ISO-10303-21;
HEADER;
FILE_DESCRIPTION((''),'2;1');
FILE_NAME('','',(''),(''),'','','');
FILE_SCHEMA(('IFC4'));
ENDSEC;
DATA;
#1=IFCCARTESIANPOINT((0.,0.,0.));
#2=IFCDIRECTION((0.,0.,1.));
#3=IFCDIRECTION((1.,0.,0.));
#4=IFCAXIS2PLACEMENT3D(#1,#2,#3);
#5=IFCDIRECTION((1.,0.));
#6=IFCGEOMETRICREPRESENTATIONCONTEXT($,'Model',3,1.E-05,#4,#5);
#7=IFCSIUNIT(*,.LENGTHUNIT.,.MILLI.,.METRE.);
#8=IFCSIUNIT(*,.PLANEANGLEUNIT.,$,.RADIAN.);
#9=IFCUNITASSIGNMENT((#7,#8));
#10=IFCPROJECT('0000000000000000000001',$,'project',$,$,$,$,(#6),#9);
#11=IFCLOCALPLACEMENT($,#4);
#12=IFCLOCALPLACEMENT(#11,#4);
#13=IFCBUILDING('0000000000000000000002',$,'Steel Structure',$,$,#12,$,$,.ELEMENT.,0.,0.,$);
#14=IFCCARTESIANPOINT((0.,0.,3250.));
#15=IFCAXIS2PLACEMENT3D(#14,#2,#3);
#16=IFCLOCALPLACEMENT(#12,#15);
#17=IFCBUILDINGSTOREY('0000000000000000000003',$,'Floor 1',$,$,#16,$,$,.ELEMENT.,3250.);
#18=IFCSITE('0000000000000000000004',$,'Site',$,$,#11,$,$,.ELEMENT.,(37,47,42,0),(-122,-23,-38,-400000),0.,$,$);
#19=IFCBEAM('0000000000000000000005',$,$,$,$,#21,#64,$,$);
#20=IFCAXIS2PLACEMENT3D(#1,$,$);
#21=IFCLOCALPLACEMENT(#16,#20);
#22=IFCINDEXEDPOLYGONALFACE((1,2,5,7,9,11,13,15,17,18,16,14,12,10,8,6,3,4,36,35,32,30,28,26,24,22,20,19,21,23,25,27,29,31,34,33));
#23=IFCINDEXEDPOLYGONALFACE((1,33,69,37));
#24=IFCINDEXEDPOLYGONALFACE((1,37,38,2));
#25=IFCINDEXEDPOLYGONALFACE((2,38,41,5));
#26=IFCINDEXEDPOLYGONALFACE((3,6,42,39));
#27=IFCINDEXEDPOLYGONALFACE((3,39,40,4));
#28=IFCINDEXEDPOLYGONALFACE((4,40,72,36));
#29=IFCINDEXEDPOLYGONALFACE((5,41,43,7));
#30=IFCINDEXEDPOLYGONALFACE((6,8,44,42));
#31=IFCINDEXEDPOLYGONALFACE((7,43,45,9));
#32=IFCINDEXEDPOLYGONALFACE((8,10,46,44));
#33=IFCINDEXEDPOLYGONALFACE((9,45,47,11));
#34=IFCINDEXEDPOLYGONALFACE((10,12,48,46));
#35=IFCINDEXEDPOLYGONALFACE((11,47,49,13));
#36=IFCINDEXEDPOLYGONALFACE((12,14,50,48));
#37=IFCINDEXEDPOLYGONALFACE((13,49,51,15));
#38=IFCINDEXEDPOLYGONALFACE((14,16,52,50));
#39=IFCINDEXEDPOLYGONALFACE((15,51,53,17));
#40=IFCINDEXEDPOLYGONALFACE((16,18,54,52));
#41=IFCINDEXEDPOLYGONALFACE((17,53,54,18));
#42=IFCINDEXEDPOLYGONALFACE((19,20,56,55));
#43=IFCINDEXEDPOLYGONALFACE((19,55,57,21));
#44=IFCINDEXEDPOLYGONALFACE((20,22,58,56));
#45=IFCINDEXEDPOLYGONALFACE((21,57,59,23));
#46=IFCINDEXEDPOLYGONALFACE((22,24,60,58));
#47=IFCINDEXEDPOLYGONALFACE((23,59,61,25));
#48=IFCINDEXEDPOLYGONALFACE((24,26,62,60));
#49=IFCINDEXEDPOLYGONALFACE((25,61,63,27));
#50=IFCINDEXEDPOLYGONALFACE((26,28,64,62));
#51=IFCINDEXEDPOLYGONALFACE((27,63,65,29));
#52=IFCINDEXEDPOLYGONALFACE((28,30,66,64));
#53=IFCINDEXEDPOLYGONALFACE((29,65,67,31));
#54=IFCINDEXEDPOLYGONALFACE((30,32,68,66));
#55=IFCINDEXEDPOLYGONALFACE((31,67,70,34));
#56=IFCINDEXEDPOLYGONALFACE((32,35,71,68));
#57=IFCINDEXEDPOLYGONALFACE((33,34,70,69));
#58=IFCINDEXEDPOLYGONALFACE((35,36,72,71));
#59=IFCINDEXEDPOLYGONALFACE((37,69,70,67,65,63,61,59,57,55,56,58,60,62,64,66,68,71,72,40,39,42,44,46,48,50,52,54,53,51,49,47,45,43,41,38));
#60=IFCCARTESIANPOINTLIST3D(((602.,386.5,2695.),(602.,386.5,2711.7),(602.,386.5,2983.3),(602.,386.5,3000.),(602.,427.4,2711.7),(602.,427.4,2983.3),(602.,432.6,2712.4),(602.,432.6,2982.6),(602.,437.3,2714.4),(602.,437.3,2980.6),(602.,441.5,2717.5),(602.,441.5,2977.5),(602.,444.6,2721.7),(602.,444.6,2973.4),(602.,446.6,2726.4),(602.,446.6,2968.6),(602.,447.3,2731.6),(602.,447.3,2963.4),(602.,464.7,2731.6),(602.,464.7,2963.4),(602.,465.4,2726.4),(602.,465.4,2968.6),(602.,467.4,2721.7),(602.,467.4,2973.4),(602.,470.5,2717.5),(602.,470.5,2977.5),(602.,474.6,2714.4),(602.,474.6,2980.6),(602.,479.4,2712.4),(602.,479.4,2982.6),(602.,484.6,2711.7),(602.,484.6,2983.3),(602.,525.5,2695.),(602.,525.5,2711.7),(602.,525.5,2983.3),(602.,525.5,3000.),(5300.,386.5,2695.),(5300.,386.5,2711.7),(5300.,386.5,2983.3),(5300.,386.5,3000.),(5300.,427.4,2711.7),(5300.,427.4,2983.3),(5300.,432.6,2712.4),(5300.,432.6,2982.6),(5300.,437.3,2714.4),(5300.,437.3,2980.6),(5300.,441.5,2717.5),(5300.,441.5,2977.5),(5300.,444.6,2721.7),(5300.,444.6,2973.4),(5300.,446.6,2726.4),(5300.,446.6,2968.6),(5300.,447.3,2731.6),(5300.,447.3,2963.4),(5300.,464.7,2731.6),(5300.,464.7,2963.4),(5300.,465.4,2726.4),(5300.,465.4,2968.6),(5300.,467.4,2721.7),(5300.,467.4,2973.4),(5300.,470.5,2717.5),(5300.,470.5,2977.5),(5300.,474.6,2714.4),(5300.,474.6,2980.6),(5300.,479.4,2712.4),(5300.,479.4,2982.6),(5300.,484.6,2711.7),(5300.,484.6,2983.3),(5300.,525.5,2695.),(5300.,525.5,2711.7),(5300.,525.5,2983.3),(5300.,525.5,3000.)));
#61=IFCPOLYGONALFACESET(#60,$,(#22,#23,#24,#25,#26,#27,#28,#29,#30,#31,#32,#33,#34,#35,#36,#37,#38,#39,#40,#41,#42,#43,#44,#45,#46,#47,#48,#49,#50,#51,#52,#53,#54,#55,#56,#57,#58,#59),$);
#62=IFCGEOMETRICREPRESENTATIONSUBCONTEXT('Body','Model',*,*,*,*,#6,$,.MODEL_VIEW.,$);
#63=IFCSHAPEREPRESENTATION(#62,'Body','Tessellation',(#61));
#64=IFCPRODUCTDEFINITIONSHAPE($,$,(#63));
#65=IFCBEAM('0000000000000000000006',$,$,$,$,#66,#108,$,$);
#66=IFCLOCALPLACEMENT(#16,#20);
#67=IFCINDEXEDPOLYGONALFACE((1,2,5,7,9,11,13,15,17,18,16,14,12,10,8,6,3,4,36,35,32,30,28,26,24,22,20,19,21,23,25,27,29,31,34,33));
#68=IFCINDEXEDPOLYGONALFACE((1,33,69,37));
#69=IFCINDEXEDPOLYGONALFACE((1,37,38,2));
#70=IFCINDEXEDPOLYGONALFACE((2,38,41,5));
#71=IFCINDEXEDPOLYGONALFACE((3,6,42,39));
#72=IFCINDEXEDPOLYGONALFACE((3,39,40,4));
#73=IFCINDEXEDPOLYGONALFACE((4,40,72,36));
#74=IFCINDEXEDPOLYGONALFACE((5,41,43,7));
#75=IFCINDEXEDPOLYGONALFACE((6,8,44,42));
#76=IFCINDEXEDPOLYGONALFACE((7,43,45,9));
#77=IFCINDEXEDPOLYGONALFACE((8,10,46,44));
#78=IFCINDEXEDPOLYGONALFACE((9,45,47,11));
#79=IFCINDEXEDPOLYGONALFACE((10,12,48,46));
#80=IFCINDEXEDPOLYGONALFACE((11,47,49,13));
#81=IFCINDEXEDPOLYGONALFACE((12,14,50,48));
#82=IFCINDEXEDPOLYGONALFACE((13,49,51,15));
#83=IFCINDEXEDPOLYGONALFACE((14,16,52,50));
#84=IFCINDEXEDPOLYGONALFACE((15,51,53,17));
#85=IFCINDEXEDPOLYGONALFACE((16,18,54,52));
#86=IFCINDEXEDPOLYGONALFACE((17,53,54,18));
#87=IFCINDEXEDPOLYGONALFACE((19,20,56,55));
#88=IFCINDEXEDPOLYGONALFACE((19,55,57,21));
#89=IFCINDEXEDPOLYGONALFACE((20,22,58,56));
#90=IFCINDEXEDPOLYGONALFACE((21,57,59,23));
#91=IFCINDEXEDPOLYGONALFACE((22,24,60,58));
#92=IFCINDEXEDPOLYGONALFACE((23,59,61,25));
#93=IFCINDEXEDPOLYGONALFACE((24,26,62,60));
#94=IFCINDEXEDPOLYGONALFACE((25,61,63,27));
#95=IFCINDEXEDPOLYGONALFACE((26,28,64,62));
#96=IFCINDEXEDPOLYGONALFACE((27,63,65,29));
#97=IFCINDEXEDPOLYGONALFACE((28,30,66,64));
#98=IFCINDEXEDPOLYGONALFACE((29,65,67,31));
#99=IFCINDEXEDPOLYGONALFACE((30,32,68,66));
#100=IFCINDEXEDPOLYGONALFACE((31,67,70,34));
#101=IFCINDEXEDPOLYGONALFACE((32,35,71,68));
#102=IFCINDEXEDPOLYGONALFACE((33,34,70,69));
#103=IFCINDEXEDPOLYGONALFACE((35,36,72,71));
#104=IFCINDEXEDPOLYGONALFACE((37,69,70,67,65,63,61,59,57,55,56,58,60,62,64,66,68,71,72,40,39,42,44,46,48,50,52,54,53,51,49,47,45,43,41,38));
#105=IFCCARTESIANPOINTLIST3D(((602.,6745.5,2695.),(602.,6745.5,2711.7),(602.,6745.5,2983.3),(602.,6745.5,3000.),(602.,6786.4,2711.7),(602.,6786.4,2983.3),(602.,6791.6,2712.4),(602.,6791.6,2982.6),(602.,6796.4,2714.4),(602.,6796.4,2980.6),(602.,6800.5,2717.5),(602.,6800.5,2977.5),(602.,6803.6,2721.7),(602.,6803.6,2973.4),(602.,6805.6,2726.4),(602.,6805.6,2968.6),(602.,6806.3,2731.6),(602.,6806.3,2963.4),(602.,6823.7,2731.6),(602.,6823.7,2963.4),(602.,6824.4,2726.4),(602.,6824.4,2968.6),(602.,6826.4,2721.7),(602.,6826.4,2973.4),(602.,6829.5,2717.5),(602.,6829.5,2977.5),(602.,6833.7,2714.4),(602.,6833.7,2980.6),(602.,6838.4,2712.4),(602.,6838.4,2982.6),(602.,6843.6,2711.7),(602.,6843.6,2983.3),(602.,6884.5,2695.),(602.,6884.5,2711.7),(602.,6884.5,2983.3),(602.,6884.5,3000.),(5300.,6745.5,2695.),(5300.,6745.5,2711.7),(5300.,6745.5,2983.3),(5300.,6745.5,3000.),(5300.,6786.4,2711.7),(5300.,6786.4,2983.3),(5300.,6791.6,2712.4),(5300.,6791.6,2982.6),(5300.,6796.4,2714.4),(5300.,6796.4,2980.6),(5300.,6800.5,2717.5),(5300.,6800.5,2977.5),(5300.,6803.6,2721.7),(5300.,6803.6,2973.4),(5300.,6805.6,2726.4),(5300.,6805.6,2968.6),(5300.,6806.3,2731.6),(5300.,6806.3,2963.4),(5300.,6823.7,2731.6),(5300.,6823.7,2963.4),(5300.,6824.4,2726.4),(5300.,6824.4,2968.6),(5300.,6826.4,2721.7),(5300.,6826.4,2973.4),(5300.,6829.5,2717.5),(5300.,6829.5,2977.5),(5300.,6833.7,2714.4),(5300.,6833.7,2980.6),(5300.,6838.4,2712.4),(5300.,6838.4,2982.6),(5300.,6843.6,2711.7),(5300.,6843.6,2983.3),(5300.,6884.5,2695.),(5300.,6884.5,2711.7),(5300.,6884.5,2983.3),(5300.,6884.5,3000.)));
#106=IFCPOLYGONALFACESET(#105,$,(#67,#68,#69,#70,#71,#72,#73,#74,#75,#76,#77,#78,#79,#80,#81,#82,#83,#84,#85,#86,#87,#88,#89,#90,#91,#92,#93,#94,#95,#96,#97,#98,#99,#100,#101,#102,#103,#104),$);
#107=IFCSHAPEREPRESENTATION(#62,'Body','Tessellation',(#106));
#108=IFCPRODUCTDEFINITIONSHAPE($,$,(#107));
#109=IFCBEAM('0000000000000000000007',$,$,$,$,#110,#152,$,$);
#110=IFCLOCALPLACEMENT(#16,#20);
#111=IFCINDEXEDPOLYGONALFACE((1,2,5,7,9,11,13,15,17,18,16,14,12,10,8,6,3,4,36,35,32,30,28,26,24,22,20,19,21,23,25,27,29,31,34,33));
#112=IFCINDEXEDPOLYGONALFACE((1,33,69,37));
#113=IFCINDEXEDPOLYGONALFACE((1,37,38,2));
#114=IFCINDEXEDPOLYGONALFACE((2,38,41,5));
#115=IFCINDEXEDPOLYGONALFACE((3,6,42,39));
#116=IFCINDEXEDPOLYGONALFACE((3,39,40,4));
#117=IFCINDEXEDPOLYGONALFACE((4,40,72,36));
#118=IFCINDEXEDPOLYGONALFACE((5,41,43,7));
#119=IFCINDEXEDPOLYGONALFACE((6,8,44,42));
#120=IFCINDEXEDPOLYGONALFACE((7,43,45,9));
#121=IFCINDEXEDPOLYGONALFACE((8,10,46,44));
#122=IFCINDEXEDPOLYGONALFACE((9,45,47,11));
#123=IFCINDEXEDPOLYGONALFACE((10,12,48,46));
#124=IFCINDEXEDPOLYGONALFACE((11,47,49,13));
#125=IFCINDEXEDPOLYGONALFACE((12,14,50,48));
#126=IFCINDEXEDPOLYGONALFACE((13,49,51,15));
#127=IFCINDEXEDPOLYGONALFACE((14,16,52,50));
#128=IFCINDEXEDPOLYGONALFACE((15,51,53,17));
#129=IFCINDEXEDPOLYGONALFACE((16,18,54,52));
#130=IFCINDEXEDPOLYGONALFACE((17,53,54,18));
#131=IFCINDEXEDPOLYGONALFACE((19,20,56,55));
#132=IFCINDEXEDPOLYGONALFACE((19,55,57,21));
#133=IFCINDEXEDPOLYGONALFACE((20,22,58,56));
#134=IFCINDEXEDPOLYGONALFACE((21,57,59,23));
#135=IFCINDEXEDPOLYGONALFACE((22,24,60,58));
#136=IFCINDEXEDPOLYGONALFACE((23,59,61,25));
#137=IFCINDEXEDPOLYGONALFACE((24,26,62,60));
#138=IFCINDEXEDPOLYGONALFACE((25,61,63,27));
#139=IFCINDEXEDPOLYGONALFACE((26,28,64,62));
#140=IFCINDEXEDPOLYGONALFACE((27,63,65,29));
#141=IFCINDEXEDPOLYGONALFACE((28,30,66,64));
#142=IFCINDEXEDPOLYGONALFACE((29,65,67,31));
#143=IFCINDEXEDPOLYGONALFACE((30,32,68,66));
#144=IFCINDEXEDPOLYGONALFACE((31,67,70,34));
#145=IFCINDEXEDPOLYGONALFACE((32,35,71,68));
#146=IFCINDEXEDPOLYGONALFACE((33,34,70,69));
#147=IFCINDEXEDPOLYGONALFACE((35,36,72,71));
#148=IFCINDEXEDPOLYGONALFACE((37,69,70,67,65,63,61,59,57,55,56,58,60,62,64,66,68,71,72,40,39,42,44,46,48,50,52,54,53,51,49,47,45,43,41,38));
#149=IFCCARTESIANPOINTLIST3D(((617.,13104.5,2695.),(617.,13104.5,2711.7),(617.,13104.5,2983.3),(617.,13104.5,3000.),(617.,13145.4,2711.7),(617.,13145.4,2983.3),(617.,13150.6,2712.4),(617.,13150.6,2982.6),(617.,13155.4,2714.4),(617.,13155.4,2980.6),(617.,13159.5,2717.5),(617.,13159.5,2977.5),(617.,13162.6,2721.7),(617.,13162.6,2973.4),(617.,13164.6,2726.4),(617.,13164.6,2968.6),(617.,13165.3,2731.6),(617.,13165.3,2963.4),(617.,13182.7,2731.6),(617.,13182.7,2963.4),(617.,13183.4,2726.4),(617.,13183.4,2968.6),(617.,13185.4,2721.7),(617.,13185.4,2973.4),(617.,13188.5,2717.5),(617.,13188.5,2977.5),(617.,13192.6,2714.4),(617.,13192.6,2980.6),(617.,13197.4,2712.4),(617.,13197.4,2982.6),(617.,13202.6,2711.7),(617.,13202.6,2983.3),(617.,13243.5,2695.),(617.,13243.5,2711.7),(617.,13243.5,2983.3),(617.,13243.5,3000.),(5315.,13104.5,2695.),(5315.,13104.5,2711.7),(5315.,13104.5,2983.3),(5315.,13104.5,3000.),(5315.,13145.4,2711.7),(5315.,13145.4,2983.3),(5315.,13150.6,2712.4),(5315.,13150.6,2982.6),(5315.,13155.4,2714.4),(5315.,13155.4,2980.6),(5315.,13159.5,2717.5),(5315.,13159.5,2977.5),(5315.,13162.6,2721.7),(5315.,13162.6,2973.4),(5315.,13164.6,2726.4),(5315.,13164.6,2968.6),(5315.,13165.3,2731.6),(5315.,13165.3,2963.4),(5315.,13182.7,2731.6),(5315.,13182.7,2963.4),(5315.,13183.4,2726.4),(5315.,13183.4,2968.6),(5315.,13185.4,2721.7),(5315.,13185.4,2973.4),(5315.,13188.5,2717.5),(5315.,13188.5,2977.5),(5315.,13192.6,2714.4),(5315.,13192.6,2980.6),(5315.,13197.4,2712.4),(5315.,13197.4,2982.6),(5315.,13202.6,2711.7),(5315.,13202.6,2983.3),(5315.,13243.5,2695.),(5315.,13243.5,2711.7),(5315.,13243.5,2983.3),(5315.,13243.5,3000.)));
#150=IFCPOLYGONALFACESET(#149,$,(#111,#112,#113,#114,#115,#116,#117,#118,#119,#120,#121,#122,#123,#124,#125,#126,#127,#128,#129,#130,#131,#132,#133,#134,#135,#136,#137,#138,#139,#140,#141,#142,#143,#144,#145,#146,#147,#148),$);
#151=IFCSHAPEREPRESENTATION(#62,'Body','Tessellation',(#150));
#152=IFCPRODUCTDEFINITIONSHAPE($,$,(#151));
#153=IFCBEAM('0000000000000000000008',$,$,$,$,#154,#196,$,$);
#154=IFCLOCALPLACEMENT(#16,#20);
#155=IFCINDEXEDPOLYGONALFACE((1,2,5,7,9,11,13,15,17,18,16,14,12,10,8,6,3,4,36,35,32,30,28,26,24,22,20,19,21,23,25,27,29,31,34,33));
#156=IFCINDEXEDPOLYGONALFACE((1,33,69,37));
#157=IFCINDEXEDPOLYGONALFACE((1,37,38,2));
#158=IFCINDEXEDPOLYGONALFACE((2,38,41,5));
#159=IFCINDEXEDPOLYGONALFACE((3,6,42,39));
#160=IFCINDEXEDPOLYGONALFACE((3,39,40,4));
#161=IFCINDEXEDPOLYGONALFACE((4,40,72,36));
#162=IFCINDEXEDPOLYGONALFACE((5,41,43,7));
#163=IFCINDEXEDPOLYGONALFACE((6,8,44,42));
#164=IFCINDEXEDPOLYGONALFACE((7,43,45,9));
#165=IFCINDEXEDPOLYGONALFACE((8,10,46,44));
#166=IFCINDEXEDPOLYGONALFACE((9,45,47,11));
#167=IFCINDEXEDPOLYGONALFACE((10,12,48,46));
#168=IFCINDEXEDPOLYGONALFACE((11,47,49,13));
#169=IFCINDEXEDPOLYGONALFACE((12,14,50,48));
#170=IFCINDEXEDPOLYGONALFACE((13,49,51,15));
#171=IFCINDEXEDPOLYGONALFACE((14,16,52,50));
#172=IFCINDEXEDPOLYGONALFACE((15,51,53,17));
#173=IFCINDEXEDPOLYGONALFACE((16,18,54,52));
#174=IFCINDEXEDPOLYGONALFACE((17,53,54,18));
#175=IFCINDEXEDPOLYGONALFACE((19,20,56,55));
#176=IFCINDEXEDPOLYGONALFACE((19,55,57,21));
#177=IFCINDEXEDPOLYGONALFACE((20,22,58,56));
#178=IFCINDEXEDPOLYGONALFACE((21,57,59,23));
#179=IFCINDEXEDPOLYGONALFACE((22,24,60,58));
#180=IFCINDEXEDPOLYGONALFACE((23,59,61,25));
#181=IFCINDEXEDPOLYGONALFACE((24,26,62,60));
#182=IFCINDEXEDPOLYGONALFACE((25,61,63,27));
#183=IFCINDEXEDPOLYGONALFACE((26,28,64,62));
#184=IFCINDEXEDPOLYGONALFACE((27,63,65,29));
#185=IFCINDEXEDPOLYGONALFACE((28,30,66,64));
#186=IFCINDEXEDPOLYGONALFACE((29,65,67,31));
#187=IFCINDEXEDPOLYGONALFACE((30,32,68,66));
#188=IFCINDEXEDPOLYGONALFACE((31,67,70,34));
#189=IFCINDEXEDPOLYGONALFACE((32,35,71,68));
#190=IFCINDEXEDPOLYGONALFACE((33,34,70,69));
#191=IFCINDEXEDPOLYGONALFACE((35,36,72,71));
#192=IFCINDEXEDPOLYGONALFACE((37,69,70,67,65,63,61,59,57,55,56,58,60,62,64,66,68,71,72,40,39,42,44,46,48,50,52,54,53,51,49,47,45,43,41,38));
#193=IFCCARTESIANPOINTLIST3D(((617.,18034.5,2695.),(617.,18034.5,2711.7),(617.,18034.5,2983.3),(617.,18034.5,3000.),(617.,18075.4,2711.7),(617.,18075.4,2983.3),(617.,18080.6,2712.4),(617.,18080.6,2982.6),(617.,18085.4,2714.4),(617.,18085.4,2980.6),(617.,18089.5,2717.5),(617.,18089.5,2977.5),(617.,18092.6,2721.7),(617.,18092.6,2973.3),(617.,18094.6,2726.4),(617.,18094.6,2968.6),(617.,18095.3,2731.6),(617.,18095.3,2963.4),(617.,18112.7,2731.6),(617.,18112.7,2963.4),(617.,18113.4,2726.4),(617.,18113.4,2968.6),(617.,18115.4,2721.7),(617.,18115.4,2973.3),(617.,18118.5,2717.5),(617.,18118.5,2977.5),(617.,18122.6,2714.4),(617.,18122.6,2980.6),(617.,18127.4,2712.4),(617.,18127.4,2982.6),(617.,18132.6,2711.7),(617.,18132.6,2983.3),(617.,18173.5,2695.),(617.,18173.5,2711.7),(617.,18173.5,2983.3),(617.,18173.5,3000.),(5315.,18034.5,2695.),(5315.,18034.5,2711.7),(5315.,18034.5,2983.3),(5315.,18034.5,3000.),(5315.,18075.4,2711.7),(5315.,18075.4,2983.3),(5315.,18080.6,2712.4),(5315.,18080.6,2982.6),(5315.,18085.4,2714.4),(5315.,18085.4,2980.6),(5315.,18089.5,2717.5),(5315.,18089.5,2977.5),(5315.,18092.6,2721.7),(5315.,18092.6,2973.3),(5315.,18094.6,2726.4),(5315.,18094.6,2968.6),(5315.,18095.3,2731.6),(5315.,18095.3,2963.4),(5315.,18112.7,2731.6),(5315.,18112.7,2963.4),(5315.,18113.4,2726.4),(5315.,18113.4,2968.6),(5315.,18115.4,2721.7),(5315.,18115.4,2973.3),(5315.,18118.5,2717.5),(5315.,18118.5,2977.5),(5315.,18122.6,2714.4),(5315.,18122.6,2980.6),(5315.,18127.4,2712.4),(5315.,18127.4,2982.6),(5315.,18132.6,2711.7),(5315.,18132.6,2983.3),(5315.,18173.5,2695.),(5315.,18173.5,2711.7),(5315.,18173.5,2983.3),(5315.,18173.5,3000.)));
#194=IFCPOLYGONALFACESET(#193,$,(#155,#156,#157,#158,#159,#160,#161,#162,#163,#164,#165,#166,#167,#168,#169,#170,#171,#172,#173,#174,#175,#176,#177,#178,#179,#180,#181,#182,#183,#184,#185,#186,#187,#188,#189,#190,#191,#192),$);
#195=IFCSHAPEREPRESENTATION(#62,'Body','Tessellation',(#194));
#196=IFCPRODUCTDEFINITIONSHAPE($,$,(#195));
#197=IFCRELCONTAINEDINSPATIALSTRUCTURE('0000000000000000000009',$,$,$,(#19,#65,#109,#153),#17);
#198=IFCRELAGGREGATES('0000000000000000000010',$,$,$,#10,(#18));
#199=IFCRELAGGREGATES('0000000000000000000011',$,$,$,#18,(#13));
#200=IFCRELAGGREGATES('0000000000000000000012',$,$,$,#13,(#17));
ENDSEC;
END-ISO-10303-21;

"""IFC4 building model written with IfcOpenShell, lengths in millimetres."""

from ifc_helpers import new_model, si_unit, direction, frame, origin_with_axes, origin_2d_with_axis, place, context, subcontext, project, spatial, i_section, extrude, element, save


model = new_model("IFC4")

# Units and contexts
model_context = context("Model", 3, precision=1e-05, world=origin_with_axes(), true_north=direction((1.0, 0.0)))
body_context = subcontext(model_context, "Body", "Model", "MODEL_VIEW")
ifc_project = project(units=[si_unit("LENGTHUNIT", "METRE", prefix="MILLI"), si_unit("PLANEANGLEUNIT", "RADIAN")], contexts=[model_context])

# Site, building, storey
site_placement = place(None, origin_with_axes())
site = spatial("IfcSite", under=ifc_project, at=site_placement, Name="Site", CompositionType="ELEMENT", RefLatitude=(37, 47, 42, 0), RefLongitude=(-122, -23, -38, -400000), RefElevation=0.0)
building_placement = place(site_placement, origin_with_axes())
building = spatial("IfcBuilding", under=site, at=building_placement, Name="Steel Structure", CompositionType="ELEMENT", ElevationOfRefHeight=0.0, ElevationOfTerrain=0.0)
storey_placement = place(building_placement, frame((0.0, 0.0, 3250.0), z_axis=(0.0, 0.0, 1.0), x_axis=(1.0, 0.0, 0.0)))
storey = spatial("IfcBuildingStorey", under=building, at=storey_placement, Name="Floor 1", CompositionType="ELEMENT", Elevation=3250.0)

# Beams
beam_1_placement = place(storey_placement, frame((602.0, 456.0, 2695.0), z_axis=(1.0, 0.0, 0.0), x_axis=(0.0, 1.0, 0.0)))
element("IfcBeam", 1, at=beam_1_placement, inside=storey, context=body_context, shape_type="SweptSolid", body=[
    extrude(i_section(OverallWidth=139.0, OverallDepth=305.0, WebThickness=17.4, FlangeThickness=16.7, FilletRadius=19.9, at=origin_2d_with_axis()), frame((0.0, 152.5, 0.0), z_axis=(0.0, 0.0, 1.0), x_axis=(1.0, 0.0, 0.0)), (0.0, 0.0, 1.0), 4698.0),
])
beam_2_placement = place(storey_placement, frame((602.0, 6815.0, 2695.0), z_axis=(1.0, 0.0, 0.0), x_axis=(0.0, 1.0, 0.0)))
element("IfcBeam", 2, at=beam_2_placement, inside=storey, context=body_context, shape_type="SweptSolid", body=[
    extrude(i_section(OverallWidth=139.0, OverallDepth=305.0, WebThickness=17.4, FlangeThickness=16.7, FilletRadius=19.9, at=origin_2d_with_axis()), frame((0.0, 152.5, 0.0), z_axis=(0.0, 0.0, 1.0), x_axis=(1.0, 0.0, 0.0)), (0.0, 0.0, 1.0), 4698.0),
])
beam_3_placement = place(storey_placement, frame((617.0, 13174.0, 2695.0), z_axis=(1.0, 0.0, 0.0), x_axis=(0.0, 1.0, 0.0)))
element("IfcBeam", 3, at=beam_3_placement, inside=storey, context=body_context, shape_type="SweptSolid", body=[
    extrude(i_section(OverallWidth=139.0, OverallDepth=305.0, WebThickness=17.4, FlangeThickness=16.7, FilletRadius=19.9, at=origin_2d_with_axis()), frame((0.0, 152.5, 0.0), z_axis=(0.0, 0.0, 1.0), x_axis=(1.0, 0.0, 0.0)), (0.0, 0.0, 1.0), 4698.0),
])
beam_4_placement = place(storey_placement, frame((5315.0, 18104.0, 2695.0), z_axis=(-1.0, 0.0, 0.0), x_axis=(0.0, -1.0, 0.0)))
element("IfcBeam", 4, at=beam_4_placement, inside=storey, context=body_context, shape_type="SweptSolid", body=[
    extrude(i_section(OverallWidth=139.0, OverallDepth=305.0, WebThickness=17.4, FlangeThickness=16.7, FilletRadius=19.9, at=origin_2d_with_axis()), frame((0.0, 152.5, 0.0), z_axis=(0.0, 0.0, 1.0), x_axis=(1.0, 0.0, 0.0)), (0.0, 0.0, 1.0), 4698.0),
])

save(model, "model.ifc")
